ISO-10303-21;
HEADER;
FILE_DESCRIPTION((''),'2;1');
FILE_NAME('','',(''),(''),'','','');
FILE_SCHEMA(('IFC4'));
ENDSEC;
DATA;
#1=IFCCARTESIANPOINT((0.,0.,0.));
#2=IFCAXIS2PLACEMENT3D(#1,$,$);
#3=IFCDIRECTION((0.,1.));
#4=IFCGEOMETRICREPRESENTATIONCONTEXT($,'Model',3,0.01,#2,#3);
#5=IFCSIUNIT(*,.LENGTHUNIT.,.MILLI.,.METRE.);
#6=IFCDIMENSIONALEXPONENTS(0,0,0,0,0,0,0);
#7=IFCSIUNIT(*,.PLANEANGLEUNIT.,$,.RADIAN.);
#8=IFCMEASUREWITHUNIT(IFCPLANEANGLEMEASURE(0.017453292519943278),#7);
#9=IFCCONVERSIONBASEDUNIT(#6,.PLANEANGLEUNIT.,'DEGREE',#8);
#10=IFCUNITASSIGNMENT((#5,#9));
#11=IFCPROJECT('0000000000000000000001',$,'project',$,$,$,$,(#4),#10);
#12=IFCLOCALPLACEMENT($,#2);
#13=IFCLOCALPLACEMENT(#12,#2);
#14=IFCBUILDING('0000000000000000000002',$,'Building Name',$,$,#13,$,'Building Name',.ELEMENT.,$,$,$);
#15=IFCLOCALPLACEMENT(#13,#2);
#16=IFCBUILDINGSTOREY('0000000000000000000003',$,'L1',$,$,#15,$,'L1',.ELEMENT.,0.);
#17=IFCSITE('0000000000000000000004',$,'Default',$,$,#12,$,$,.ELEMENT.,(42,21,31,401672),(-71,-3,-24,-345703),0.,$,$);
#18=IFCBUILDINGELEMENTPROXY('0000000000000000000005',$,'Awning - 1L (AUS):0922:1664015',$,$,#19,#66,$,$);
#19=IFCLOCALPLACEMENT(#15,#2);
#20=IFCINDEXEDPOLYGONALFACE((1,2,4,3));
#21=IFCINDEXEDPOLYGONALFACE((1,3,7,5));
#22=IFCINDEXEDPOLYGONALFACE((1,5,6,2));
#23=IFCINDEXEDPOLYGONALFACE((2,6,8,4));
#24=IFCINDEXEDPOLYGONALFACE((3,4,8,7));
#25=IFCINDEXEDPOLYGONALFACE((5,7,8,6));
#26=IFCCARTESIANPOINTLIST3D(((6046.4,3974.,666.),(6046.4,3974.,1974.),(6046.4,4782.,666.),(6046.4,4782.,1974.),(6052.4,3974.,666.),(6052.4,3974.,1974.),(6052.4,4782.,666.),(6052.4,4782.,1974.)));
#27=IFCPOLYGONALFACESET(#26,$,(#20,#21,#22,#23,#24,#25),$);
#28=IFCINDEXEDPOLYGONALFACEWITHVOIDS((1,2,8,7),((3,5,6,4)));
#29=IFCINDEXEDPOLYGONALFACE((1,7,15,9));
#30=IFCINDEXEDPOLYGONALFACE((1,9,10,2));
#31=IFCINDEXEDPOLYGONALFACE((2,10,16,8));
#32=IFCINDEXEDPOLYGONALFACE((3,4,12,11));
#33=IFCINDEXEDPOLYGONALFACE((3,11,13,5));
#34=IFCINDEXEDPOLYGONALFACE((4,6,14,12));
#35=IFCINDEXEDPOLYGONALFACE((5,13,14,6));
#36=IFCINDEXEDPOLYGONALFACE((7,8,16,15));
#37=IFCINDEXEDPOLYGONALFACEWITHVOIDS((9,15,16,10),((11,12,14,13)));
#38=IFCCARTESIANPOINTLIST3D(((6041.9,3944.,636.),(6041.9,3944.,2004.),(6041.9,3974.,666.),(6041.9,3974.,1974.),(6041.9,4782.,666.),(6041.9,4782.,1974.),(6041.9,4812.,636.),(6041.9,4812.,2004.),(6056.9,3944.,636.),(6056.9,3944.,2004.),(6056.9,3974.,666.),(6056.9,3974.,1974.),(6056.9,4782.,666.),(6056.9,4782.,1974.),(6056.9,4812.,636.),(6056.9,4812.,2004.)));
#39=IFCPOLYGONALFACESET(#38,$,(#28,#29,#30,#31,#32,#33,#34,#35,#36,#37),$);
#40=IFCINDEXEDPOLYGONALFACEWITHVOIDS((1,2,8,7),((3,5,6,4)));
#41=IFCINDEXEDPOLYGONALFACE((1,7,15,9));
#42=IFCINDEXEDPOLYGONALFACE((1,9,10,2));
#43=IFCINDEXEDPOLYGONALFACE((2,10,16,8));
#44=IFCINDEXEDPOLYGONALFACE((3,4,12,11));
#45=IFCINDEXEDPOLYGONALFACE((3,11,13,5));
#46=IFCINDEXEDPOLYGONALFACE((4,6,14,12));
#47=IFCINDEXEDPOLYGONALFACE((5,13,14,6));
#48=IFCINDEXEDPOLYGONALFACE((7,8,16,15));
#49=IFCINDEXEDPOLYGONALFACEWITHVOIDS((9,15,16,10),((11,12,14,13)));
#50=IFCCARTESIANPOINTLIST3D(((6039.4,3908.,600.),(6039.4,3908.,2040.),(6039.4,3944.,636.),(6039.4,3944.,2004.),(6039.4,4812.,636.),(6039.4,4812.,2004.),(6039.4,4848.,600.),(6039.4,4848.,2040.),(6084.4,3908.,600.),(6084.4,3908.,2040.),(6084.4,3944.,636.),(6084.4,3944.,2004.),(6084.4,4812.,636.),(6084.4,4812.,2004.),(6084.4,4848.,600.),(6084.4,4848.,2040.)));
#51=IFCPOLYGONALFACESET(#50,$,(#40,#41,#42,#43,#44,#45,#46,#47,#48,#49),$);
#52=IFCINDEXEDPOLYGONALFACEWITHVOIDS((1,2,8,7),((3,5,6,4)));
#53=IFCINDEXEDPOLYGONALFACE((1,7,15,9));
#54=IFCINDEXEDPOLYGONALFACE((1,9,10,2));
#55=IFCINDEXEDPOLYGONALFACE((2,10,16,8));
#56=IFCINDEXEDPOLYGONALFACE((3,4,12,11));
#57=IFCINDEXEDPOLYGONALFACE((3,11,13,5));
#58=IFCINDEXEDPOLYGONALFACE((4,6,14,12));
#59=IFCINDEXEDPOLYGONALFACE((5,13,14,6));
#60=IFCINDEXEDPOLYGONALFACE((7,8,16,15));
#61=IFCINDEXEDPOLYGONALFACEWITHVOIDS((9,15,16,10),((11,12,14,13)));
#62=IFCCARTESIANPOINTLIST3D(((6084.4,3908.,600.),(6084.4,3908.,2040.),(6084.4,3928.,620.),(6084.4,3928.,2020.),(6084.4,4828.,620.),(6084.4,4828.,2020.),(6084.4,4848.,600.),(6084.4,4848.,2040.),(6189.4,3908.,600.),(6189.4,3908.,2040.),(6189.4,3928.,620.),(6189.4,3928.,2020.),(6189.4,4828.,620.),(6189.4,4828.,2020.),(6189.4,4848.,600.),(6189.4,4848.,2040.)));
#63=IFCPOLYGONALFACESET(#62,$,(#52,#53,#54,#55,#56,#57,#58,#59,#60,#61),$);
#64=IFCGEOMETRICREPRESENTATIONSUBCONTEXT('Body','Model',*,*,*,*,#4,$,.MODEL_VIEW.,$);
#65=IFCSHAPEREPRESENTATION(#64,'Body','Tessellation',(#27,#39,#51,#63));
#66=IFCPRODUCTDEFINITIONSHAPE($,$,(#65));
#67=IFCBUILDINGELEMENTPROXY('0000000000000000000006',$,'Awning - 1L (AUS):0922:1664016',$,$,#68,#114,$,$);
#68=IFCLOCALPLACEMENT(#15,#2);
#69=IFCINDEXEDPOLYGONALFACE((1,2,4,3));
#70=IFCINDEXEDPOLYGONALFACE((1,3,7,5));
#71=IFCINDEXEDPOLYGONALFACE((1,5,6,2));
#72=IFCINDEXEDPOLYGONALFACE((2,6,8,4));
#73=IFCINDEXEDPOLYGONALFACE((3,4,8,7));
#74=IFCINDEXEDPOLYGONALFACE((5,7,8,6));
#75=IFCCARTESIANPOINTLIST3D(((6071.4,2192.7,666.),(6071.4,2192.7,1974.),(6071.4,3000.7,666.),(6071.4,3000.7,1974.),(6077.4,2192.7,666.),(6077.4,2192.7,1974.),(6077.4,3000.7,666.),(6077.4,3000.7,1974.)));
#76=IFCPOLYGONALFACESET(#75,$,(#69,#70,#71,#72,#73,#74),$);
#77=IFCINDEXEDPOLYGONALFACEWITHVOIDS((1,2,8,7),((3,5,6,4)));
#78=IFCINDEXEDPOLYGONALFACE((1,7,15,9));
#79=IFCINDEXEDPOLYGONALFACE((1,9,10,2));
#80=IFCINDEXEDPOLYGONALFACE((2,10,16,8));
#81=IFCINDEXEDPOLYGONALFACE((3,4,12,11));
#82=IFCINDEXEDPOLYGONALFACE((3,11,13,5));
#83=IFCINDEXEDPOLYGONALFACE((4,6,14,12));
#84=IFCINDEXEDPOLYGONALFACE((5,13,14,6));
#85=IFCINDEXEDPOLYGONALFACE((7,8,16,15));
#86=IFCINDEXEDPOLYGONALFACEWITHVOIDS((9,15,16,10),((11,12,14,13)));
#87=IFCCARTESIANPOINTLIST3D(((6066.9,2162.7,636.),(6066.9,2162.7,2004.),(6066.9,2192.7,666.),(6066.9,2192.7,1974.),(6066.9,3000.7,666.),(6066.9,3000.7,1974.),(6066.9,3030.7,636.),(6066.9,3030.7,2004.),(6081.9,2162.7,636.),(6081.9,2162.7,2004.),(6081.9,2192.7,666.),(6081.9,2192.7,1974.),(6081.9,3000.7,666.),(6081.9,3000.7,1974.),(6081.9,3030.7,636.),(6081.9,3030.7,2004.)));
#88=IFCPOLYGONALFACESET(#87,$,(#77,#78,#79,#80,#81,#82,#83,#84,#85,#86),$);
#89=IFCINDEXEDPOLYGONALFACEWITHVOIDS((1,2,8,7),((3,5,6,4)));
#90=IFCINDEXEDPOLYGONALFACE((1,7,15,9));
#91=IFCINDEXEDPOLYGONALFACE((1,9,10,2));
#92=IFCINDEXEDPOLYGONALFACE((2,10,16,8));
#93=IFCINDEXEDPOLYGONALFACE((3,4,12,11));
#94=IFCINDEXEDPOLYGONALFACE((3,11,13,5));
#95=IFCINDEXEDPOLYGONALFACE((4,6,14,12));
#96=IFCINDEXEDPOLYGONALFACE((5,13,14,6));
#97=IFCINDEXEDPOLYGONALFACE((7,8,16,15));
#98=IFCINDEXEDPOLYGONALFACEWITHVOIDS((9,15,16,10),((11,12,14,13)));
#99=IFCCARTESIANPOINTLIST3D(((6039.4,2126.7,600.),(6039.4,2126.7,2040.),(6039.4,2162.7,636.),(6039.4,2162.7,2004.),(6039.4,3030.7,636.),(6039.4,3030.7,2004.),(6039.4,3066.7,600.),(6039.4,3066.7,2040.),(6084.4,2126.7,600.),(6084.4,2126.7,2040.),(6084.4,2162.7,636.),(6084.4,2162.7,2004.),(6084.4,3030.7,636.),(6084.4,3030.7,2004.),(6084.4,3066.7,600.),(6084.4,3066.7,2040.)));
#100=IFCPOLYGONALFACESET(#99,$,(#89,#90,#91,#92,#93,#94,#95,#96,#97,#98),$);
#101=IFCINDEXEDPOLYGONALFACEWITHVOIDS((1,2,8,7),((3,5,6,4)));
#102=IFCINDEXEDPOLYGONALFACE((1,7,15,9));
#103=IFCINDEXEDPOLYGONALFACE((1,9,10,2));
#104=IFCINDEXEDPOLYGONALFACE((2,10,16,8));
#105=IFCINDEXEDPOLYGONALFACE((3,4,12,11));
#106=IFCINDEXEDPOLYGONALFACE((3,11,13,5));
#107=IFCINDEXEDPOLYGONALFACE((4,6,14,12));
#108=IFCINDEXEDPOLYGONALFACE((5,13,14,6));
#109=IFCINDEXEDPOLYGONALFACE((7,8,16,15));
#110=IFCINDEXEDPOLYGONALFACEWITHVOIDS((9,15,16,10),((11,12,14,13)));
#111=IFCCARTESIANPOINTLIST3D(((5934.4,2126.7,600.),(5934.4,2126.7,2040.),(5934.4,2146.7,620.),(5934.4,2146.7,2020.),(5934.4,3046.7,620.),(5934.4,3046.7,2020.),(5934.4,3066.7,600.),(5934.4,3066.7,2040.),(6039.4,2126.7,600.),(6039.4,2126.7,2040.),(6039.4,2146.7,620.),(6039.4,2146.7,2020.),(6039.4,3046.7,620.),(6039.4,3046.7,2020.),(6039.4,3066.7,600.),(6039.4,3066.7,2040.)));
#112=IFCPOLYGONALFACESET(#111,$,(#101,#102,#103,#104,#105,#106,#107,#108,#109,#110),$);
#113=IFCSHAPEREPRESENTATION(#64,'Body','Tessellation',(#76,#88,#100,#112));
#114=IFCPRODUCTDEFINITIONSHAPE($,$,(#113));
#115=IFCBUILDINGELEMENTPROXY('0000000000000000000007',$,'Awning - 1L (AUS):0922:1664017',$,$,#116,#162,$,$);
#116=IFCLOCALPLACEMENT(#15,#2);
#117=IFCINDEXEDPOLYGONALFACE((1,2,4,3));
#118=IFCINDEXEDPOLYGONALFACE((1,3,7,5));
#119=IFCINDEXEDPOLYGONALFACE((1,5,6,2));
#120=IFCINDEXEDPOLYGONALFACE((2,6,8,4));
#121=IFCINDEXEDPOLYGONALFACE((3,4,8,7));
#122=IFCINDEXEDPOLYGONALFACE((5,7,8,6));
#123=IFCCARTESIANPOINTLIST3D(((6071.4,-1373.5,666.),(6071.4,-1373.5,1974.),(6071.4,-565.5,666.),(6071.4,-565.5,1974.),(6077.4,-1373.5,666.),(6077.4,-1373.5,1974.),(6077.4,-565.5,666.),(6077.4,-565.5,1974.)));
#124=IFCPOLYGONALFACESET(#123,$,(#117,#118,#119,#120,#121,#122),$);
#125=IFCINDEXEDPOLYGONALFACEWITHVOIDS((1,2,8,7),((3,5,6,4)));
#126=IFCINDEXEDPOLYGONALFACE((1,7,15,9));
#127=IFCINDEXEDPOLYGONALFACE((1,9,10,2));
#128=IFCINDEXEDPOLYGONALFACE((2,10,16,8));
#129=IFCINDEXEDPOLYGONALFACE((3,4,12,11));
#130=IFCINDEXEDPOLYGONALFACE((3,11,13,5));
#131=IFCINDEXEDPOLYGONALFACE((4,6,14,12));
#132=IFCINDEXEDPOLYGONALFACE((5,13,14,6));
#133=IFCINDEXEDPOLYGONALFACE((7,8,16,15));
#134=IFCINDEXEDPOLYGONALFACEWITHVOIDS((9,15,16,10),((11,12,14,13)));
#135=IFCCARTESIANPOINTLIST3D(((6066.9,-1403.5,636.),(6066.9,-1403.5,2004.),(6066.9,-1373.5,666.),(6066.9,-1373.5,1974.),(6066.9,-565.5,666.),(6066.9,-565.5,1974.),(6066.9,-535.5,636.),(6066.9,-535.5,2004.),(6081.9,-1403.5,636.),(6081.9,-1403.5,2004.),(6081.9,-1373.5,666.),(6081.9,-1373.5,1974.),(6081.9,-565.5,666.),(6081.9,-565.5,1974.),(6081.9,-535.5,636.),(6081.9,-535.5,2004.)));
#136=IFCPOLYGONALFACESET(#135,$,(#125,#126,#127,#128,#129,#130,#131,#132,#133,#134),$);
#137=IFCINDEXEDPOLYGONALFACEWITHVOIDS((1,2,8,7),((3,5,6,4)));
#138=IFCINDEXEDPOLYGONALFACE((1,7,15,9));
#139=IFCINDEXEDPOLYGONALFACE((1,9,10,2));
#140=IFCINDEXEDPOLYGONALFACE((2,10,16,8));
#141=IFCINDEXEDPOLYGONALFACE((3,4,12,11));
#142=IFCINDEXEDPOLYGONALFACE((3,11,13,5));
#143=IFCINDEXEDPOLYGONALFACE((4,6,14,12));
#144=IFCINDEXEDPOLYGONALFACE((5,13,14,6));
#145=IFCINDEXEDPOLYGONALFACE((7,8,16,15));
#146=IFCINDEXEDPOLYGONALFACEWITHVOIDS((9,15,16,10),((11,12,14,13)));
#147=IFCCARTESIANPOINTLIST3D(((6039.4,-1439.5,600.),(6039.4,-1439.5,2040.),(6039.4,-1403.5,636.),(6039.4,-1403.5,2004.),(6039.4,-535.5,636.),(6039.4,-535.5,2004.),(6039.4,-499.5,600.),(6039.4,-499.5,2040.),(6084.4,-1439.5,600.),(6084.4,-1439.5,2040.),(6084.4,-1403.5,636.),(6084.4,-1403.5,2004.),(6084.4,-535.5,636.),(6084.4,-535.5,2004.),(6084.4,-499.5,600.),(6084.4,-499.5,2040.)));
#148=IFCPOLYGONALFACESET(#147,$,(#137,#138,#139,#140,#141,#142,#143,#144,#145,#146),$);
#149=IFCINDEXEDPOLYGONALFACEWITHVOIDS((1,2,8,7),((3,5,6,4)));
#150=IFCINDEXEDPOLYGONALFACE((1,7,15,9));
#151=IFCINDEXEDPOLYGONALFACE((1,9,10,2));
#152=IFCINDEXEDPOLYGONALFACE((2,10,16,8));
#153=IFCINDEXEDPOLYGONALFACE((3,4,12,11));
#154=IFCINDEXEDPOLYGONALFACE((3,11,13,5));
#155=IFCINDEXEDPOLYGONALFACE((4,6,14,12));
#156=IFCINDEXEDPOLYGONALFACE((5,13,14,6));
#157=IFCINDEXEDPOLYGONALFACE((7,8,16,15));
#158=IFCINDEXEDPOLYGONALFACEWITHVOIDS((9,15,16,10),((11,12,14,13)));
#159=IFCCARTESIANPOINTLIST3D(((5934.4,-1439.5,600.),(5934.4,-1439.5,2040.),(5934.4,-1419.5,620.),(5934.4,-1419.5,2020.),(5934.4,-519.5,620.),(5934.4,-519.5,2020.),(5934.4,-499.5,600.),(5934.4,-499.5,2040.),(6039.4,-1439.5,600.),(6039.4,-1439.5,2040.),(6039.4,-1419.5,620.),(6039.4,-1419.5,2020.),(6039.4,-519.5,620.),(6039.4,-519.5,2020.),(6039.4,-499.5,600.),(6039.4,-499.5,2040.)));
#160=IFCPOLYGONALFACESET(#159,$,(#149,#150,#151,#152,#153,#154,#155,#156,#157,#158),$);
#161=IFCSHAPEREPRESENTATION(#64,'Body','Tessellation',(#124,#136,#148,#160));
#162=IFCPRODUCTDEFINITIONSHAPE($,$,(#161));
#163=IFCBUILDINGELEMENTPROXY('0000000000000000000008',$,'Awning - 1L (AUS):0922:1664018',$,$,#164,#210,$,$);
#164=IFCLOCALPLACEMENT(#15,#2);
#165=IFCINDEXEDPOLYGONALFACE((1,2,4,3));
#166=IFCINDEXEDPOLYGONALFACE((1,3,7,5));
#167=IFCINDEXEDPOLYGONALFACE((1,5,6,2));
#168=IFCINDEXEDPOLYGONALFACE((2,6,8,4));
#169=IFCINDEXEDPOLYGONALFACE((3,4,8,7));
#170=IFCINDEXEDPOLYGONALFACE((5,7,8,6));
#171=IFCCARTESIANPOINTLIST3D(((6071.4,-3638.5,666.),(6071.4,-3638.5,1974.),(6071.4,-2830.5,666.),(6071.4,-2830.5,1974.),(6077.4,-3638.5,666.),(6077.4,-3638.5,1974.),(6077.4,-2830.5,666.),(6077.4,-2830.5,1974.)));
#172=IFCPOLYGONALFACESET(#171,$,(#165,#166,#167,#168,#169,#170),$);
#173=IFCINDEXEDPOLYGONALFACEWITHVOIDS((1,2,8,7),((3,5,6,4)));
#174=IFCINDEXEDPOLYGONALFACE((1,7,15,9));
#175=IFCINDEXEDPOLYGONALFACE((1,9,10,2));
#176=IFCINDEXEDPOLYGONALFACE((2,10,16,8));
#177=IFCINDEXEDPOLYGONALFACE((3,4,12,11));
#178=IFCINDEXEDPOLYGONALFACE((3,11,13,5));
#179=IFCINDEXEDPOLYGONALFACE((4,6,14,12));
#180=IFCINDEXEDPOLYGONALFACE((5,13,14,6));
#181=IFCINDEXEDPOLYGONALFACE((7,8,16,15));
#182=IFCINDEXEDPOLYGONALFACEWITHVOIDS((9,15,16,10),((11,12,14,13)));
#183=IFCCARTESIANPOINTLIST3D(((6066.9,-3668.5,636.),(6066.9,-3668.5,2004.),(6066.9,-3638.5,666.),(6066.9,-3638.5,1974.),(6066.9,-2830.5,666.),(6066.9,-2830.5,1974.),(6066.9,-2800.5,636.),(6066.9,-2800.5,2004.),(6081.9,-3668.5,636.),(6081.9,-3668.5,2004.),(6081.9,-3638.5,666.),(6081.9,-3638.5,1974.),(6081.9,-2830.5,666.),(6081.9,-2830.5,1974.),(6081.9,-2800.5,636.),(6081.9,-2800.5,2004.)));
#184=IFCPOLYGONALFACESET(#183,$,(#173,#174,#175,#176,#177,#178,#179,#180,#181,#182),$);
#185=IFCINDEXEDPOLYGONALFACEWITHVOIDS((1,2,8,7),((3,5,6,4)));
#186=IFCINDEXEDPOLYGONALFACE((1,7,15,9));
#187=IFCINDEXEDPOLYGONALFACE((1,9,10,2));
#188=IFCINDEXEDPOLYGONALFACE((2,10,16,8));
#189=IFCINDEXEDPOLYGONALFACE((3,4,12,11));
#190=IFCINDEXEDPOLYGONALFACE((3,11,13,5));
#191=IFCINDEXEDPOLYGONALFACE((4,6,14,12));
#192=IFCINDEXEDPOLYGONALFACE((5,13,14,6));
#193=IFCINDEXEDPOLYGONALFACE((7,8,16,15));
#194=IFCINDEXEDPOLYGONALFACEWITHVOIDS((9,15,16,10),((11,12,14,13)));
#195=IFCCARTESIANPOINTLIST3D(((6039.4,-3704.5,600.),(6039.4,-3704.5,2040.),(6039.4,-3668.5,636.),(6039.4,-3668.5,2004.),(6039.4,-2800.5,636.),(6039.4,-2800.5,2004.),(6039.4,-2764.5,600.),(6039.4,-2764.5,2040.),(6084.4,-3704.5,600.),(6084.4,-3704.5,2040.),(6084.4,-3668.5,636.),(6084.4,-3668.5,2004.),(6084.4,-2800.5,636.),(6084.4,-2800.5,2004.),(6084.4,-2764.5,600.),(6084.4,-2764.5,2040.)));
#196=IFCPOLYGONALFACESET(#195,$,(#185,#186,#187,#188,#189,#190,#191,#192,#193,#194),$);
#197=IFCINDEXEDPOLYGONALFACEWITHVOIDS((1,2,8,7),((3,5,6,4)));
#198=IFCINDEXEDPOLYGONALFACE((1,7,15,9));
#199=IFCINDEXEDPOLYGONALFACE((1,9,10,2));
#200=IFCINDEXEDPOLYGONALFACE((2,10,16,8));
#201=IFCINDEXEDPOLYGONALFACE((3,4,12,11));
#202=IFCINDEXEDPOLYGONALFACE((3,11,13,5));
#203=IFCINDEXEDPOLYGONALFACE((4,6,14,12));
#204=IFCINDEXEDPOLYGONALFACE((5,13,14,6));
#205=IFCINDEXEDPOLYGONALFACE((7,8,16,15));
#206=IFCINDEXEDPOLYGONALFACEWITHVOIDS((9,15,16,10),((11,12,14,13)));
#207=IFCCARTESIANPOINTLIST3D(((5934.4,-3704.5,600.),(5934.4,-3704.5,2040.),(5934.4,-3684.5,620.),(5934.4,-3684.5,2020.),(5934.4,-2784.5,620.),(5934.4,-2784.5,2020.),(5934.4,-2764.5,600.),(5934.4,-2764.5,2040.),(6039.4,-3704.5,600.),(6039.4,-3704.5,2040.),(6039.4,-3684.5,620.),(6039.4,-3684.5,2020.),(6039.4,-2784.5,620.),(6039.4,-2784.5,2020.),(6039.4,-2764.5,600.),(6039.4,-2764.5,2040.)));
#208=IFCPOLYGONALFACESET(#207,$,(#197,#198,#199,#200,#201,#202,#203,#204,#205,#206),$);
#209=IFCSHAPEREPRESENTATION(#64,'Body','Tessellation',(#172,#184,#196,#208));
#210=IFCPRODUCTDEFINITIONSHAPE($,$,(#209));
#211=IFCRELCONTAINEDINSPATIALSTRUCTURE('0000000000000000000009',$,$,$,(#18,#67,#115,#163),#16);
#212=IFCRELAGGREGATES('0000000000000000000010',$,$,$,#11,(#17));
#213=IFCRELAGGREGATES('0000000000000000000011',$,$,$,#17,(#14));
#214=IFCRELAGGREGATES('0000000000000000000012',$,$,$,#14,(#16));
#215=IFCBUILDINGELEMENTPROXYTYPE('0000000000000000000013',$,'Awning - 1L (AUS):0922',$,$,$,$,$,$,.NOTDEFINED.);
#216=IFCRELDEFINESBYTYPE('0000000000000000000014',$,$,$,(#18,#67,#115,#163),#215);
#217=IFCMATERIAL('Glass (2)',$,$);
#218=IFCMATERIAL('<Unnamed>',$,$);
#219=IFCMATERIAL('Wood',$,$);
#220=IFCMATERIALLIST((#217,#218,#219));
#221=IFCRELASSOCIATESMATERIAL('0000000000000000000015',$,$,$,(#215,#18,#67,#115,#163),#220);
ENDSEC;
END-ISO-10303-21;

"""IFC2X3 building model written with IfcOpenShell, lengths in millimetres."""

from ifc_helpers import new_model, entity, si_unit, converted_unit, direction, frame, frame_2d, origin, place, context, subcontext, project, spatial, polyline, rectangle, outline, extrude, source, transform, mapped, material, material_list, type_object, type_shapes, element, save


model = new_model("IFC2X3")

# Units and contexts
model_context = context("Model", 3, precision=0.01, world=origin(), true_north=direction((0.0, 1.0)))
body_context = subcontext(model_context, "Body", "Model", "MODEL_VIEW")
ifc_project = project(units=[si_unit("LENGTHUNIT", "METRE", prefix="MILLI"), converted_unit("PLANEANGLEUNIT", "DEGREE", entity("IfcPlaneAngleMeasure", 0.017453292519943278), si_unit("PLANEANGLEUNIT", "RADIAN"), dimensions=[0, 0, 0, 0, 0, 0, 0])], contexts=[model_context])

# Site, building, storey
site_placement = place(None, origin())
site = spatial("IfcSite", under=ifc_project, at=site_placement, Name="Default", CompositionType="ELEMENT", RefLatitude=(42, 21, 31, 401672), RefLongitude=(-71, -3, -24, -345703), RefElevation=0.0)
building_placement = place(site_placement, origin())
building = spatial("IfcBuilding", under=site, at=building_placement, Name="Building Name", LongName="Building Name", CompositionType="ELEMENT")
storey_placement = place(building_placement, origin())
storey = spatial("IfcBuildingStorey", under=building, at=storey_placement, Name="L1", LongName="L1", CompositionType="ELEMENT", Elevation=0.0)

# Building element proxies
ifc_material_1 = material(Name="Glass (2)")
ifc_material_2 = material(Name="<Unnamed>")
ifc_material_3 = material(Name="Wood")
ifc_material_list = material_list([ifc_material_1, ifc_material_2, ifc_material_3])
building_element_proxy_type_1 = type_object("IfcBuildingElementProxyType", Name="Awning - 1L (AUS):0922", PredefinedType="NOTDEFINED", material=ifc_material_list)
shared_shape = source(origin(), body_context, "Body", "SweptSolid", [
    extrude(rectangle(XDim=6.0, YDim=808.0, at=frame_2d((0.0, 0.0), x_axis=(1.0, 0.0))), frame((326.2, 12.5, 966.0), z_axis=(0.0, 0.0, 1.0), x_axis=(0.0, 1.0, 0.0)), (0.0, 0.0, 1.0), 1308.0),
    extrude(outline(polyline([(-684.0, -434.0), (684.0, -434.0), (684.0, 434.0), (-684.0, 434.0), (-684.0, -434.0)]), holes=[polyline([(654.0, -404.0), (-654.0, -404.0), (-654.0, 404.0), (654.0, 404.0), (654.0, -404.0)])]), frame((326.2, 5.0, 1620.0), z_axis=(0.0, 1.0, 0.0), x_axis=(0.0, 0.0, 1.0)), (0.0, 0.0, 1.0), 15.0),
    extrude(outline(polyline([(-720.0, -470.0), (720.0, -470.0), (720.0, 470.0), (-720.0, 470.0), (-720.0, -470.0)]), holes=[polyline([(684.0, -434.0), (-684.0, -434.0), (-684.0, 434.0), (684.0, 434.0), (684.0, -434.0)])]), frame((326.2, -22.5, 1620.0), z_axis=(0.0, 1.0, 0.0), x_axis=(0.0, 0.0, 1.0)), (0.0, 0.0, 1.0), 45.0),
    extrude(outline(polyline([(-720.0, -470.0), (720.0, -470.0), (720.0, 470.0), (-720.0, 470.0), (-720.0, -470.0)]), holes=[polyline([(700.0, -450.0), (-700.0, -450.0), (-700.0, 450.0), (700.0, 450.0), (700.0, -450.0)])]), frame((326.2, -127.5, 1620.0), z_axis=(0.0, 1.0, 0.0), x_axis=(0.0, 0.0, 1.0)), (0.0, 0.0, 1.0), 105.0),
])
type_shapes(building_element_proxy_type_1, [shared_shape])
for number, where, z_axis, x_axis, name in (
    (1, (6061.9, 4051.8, -300.0), (0.0, 0.0, 1.0), (0.0, 1.0, 0.0), "Awning - 1L (AUS):0922:1664015"),
    (2, (6061.9, 2922.9, -300.0), (0.0, 0.0, 1.0), (0.0, -1.0, 0.0), "Awning - 1L (AUS):0922:1664016"),
    (3, (6061.9, -643.3, -300.0), (0.0, 0.0, 1.0), (0.0, -1.0, 0.0), "Awning - 1L (AUS):0922:1664017"),
    (4, (6061.9, -2908.3, -300.0), (0.0, 0.0, 1.0), (0.0, -1.0, 0.0), "Awning - 1L (AUS):0922:1664018"),
):
    element("IfcBuildingElementProxy", number, at=place(storey_placement, frame(where, z_axis=z_axis, x_axis=x_axis)), inside=storey, type_object=building_element_proxy_type_1, material=ifc_material_list, Name=name, context=body_context, shape_type="MappedRepresentation", body=[
        mapped(shared_shape, transform((0.0, 0.0, 0.0), scale=1.0)),
    ])

save(model, "model.ifc")
